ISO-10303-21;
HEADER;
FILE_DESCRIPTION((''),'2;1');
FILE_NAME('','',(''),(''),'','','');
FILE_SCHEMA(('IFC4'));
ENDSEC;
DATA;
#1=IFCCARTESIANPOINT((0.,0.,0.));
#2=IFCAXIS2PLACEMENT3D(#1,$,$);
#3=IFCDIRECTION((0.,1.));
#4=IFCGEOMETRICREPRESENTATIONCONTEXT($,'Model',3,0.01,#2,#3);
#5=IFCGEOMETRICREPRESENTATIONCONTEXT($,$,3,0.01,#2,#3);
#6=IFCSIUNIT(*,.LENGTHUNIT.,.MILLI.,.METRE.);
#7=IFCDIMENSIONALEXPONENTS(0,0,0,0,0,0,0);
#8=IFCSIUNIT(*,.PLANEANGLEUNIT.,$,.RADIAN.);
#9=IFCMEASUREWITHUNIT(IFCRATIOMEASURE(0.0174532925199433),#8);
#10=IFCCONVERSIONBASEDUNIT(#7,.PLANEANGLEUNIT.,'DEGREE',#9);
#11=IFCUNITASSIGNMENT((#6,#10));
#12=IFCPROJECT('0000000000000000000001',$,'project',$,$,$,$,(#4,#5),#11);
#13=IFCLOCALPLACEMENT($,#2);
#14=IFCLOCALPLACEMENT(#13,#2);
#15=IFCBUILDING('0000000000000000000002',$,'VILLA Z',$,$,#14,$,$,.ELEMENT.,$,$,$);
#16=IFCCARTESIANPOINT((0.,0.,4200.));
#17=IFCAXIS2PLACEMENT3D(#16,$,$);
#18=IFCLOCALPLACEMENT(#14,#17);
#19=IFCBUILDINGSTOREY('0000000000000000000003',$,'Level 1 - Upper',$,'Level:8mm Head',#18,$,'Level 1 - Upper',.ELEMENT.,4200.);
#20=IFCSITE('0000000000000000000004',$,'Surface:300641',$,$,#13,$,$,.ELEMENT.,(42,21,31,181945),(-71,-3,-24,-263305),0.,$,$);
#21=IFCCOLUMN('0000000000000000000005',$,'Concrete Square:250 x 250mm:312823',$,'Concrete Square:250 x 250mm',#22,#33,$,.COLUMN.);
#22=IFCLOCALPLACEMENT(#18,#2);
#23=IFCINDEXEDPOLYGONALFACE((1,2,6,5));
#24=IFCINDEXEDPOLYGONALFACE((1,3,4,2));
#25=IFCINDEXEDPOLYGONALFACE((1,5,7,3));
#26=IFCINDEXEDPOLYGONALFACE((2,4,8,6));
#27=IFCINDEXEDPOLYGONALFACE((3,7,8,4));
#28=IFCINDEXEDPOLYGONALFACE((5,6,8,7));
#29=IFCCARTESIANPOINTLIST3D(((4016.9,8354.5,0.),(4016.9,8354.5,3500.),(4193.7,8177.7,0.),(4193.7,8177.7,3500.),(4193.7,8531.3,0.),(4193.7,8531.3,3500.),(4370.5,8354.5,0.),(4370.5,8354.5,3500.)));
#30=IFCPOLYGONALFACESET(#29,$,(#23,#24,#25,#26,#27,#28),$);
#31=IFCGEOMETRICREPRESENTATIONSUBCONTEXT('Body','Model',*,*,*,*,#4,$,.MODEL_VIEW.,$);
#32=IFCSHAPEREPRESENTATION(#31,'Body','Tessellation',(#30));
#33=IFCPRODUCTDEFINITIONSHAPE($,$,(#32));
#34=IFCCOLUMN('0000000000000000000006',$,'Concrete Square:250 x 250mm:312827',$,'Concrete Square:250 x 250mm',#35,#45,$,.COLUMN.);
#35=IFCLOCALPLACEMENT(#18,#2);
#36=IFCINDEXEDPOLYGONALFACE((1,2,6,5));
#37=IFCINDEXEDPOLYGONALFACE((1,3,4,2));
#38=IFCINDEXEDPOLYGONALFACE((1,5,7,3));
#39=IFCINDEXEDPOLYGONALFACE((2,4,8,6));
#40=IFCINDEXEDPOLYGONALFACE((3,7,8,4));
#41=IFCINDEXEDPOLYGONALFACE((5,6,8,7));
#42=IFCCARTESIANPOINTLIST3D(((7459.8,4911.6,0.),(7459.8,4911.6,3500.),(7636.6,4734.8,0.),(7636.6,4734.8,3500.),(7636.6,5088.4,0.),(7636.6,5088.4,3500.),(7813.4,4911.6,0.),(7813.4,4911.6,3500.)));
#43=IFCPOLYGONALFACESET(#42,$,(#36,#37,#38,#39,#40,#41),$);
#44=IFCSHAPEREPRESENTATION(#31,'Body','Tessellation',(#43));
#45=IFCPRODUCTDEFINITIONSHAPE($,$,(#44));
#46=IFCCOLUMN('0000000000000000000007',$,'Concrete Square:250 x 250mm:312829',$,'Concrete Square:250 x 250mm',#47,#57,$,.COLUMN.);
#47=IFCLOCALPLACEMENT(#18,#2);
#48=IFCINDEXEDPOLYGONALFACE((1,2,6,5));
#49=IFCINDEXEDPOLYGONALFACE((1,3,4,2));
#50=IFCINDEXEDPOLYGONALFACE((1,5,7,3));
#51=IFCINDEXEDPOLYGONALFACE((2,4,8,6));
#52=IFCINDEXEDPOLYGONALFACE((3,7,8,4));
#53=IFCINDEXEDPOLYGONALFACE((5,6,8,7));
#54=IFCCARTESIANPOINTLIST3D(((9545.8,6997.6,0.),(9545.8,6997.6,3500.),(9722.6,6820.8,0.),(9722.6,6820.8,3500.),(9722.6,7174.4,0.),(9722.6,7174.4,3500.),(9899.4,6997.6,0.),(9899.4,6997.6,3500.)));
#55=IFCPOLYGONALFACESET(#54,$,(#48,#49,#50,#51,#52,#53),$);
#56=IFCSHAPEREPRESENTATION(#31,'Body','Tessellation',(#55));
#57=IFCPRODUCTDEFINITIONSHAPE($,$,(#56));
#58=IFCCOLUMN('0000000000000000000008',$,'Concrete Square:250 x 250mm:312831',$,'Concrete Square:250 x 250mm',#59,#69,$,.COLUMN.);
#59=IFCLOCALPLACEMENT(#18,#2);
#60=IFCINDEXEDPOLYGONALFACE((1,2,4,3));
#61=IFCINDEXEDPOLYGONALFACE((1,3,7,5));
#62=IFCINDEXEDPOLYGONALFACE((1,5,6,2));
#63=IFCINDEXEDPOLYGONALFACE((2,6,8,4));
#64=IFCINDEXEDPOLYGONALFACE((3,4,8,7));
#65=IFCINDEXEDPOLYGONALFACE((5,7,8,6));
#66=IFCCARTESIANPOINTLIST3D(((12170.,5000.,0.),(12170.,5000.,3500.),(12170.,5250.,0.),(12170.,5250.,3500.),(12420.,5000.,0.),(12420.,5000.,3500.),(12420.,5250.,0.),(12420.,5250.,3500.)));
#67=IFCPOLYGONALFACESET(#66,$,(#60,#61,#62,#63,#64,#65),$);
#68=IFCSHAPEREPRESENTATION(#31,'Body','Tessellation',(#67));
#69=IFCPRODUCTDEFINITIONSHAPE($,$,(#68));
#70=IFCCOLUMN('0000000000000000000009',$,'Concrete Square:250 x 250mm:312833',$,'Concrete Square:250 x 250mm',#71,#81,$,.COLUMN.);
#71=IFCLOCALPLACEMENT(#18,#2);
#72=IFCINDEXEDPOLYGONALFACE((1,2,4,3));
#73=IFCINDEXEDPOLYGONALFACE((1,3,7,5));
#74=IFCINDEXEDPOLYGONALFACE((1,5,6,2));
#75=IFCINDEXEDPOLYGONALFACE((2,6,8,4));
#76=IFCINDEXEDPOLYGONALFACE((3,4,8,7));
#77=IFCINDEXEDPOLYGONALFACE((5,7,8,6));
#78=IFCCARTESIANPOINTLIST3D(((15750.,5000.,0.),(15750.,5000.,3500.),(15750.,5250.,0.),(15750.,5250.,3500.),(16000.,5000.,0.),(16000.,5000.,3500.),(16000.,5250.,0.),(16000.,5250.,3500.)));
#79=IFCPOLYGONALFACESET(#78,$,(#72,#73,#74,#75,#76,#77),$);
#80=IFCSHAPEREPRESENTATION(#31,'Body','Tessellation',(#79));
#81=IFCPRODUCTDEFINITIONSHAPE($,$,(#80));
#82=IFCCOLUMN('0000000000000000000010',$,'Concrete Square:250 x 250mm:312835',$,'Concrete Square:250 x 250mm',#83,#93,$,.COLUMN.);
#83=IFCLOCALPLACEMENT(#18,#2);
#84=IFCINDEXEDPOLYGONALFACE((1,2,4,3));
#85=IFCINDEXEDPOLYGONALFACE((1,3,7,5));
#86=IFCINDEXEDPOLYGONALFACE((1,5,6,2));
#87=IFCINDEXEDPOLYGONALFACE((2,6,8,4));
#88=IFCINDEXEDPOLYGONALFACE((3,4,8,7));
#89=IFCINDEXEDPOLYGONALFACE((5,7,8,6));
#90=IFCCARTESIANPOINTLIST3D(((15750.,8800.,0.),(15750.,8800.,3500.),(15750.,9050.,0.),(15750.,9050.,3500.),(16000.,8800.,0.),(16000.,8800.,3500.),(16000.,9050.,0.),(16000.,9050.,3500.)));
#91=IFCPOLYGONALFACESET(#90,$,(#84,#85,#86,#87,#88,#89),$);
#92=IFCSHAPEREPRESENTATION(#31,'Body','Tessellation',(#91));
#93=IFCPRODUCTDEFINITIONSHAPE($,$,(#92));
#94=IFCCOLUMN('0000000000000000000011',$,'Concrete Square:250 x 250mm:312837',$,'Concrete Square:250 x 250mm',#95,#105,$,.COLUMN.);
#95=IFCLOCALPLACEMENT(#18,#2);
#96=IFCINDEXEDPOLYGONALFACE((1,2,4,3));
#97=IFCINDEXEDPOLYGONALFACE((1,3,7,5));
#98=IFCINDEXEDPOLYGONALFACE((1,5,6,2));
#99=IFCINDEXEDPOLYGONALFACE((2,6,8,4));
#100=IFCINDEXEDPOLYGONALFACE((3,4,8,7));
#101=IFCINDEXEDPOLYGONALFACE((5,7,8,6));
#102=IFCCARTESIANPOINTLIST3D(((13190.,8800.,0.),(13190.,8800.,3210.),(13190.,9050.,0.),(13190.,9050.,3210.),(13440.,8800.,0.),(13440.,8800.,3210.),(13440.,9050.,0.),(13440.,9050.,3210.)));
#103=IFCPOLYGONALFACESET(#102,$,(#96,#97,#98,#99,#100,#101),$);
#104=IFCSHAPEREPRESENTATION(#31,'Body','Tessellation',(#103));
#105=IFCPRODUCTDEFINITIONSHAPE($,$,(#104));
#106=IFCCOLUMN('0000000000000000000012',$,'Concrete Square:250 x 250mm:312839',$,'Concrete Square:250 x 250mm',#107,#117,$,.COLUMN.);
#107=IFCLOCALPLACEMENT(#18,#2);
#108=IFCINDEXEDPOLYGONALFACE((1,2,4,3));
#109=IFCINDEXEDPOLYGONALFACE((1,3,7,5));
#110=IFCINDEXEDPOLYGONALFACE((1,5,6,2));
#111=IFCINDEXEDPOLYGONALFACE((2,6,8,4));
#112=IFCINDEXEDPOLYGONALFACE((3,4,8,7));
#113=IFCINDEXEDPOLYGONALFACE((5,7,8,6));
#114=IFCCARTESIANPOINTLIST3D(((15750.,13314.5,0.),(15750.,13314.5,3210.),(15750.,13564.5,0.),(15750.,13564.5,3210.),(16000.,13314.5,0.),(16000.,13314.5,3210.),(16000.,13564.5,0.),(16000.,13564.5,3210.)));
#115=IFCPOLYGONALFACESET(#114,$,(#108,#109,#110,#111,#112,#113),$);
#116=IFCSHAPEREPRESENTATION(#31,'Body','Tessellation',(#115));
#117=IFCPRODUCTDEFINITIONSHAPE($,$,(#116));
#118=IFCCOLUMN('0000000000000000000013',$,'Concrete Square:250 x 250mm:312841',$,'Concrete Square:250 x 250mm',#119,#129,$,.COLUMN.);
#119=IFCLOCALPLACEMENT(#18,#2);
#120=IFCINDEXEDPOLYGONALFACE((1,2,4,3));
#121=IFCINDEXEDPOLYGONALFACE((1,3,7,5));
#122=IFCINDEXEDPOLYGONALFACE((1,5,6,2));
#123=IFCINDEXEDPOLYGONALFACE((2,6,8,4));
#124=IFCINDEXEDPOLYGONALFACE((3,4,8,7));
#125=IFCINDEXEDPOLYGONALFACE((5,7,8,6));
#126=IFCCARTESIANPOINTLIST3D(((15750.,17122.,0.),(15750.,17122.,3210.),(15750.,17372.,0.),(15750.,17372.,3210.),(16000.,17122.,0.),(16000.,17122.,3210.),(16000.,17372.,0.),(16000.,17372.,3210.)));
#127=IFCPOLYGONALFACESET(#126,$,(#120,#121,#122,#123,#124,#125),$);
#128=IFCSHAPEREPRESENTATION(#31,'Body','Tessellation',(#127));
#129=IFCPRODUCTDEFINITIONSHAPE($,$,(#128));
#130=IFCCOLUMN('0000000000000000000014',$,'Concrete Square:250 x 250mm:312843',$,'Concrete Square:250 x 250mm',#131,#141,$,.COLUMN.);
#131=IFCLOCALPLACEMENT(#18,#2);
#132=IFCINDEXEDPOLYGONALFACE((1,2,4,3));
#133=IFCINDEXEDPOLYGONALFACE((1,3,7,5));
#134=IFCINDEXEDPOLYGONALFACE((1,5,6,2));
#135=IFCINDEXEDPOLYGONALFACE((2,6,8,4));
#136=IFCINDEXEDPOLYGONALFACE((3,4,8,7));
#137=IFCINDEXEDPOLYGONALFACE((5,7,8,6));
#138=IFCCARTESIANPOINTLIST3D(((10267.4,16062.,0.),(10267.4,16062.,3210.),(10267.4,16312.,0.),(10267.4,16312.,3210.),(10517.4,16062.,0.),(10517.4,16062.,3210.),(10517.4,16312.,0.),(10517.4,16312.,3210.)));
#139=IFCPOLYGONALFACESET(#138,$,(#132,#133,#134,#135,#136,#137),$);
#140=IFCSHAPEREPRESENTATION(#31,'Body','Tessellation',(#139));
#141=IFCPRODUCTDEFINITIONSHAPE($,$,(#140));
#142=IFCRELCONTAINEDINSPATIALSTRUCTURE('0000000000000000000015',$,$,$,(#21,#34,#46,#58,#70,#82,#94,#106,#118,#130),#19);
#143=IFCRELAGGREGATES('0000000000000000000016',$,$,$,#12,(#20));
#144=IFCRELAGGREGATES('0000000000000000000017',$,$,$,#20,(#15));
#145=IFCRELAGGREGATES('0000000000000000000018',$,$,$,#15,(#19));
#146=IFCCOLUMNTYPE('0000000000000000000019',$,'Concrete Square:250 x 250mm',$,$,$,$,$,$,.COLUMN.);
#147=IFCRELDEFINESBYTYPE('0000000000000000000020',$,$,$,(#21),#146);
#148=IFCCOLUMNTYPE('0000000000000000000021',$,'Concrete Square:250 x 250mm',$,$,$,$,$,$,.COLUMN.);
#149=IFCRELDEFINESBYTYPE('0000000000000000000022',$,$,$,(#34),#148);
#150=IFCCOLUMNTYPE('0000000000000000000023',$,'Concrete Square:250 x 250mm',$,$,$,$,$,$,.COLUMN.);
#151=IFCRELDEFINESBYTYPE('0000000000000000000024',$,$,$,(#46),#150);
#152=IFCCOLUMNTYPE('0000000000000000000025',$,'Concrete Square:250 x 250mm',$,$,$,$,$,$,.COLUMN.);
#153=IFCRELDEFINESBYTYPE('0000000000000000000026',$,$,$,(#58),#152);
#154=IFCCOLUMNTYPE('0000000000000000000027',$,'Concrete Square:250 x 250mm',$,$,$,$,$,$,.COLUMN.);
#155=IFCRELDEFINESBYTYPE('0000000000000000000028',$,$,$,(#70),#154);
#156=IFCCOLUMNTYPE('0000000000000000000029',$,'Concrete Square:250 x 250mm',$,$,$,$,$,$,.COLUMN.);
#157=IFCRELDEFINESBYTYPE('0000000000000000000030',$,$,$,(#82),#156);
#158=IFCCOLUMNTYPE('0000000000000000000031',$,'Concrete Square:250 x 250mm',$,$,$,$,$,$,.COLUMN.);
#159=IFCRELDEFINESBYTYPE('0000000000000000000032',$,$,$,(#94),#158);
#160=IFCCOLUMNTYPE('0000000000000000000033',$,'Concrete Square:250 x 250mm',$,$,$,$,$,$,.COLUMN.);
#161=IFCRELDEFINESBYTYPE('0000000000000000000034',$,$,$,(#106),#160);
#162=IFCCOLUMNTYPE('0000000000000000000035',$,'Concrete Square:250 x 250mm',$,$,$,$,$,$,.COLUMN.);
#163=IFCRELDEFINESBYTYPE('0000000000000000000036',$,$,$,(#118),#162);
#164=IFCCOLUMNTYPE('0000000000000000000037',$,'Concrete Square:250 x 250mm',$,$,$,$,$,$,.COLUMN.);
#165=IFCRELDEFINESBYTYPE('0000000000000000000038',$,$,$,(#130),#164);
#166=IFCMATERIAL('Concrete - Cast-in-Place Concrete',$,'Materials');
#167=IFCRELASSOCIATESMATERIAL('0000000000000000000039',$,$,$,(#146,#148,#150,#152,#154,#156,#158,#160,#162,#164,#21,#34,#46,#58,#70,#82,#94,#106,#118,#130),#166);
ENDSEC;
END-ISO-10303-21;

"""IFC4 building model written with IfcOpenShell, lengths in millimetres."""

from ifc_helpers import new_model, entity, si_unit, converted_unit, direction, frame, frame_2d, origin, origin_2d_with_axis, place, context, subcontext, project, spatial, rectangle, extrude, source, transform, mapped, material, material_profile, profile_set, profile_usage, type_object, type_shapes, element, save


model = new_model("IFC4")

# Units and contexts
model_context = context("Model", 3, precision=0.01, world=origin(), true_north=direction((0.0, 1.0)))
context_of_model = context(None, 3, precision=0.01, world=origin(), true_north=direction((0.0, 1.0)))
body_context = subcontext(model_context, "Body", "Model", "MODEL_VIEW")
ifc_project = project(units=[si_unit("LENGTHUNIT", "METRE", prefix="MILLI"), converted_unit("PLANEANGLEUNIT", "DEGREE", entity("IfcRatioMeasure", 0.0174532925199433), si_unit("PLANEANGLEUNIT", "RADIAN"), dimensions=[0, 0, 0, 0, 0, 0, 0])], contexts=[model_context, context_of_model])

# Site, building, storey
site_placement = place(None, origin())
site = spatial("IfcSite", under=ifc_project, at=site_placement, Name="Surface:300641", CompositionType="ELEMENT", RefLatitude=(42, 21, 31, 181945), RefLongitude=(-71, -3, -24, -263305), RefElevation=0.0)
building_placement = place(site_placement, origin())
building = spatial("IfcBuilding", under=site, at=building_placement, Name="VILLA Z", CompositionType="ELEMENT")
storey_placement = place(building_placement, frame((0.0, 0.0, 4200.0)))
storey = spatial("IfcBuildingStorey", under=building, at=storey_placement, Name="Level 1 - Upper", ObjectType="Level:8mm Head", LongName="Level 1 - Upper", CompositionType="ELEMENT", Elevation=4200.0)

# Columns
ifc_material = material(Name="Concrete - Cast-in-Place Concrete", Category="Materials")
ifc_material_profile_1 = material_profile(ifc_material, rectangle(XDim=250.0, YDim=250.0, at=frame_2d((0.0, 0.0), x_axis=(1.0, 0.0))), Name="250 x 250mm")
ifc_profile_set_1 = profile_set([ifc_material_profile_1], Name="250 x 250mm")
ifc_profile_usage_1 = profile_usage(ifc_profile_set_1)
column_type_1 = type_object("IfcColumnType", Name="Concrete Square:250 x 250mm", PredefinedType="COLUMN", material=ifc_profile_set_1)
shared_shape_1 = source(origin(), body_context, "Body", "SweptSolid", [
    extrude(rectangle(XDim=250.0, YDim=250.0, at=frame_2d((0.0, 0.0), x_axis=(1.0, 0.0))), frame((4193.7, 8354.5, 4200.0), z_axis=(0.0, 0.0, 1.0), x_axis=(-0.707107, 0.707107, 0.0)), (0.0, 0.0, 1.0), 3500.0),
])
type_shapes(column_type_1, [shared_shape_1])
column_1_placement = place(storey_placement, frame((0.0, 0.0, -4200.0)))
element("IfcColumn", 1, at=column_1_placement, inside=storey, type_object=column_type_1, material=ifc_profile_usage_1, Name="Concrete Square:250 x 250mm:312823", ObjectType="Concrete Square:250 x 250mm", PredefinedType="COLUMN", context=body_context, shape_type="MappedRepresentation", body=[
    mapped(shared_shape_1, transform((0.0, 0.0, 0.0), scale=1.0)),
])
ifc_profile_usage_2 = profile_usage(ifc_profile_set_1)
column_type_2 = type_object("IfcColumnType", Name="Concrete Square:250 x 250mm", PredefinedType="COLUMN", material=ifc_profile_set_1)
shared_shape_2 = source(origin(), body_context, "Body", "SweptSolid", [
    extrude(rectangle(XDim=250.0, YDim=250.0, at=frame_2d((0.0, 0.0), x_axis=(1.0, 0.0))), frame((7636.6, 4911.6, 4200.0), z_axis=(0.0, 0.0, 1.0), x_axis=(-0.707107, 0.707107, 0.0)), (0.0, 0.0, 1.0), 3500.0),
])
type_shapes(column_type_2, [shared_shape_2])
column_2_placement = place(storey_placement, frame((0.0, 0.0, -4200.0)))
element("IfcColumn", 2, at=column_2_placement, inside=storey, type_object=column_type_2, material=ifc_profile_usage_2, Name="Concrete Square:250 x 250mm:312827", ObjectType="Concrete Square:250 x 250mm", PredefinedType="COLUMN", context=body_context, shape_type="MappedRepresentation", body=[
    mapped(shared_shape_2, transform((0.0, 0.0, 0.0), scale=1.0)),
])
ifc_profile_usage_3 = profile_usage(ifc_profile_set_1)
column_type_3 = type_object("IfcColumnType", Name="Concrete Square:250 x 250mm", PredefinedType="COLUMN", material=ifc_profile_set_1)
shared_shape_3 = source(origin(), body_context, "Body", "SweptSolid", [
    extrude(rectangle(XDim=250.0, YDim=250.0, at=frame_2d((0.0, 0.0), x_axis=(1.0, 0.0))), frame((9722.6, 6997.6, 4200.0), z_axis=(0.0, 0.0, 1.0), x_axis=(-0.707107, 0.707107, 0.0)), (0.0, 0.0, 1.0), 3500.0),
])
type_shapes(column_type_3, [shared_shape_3])
column_3_placement = place(storey_placement, frame((0.0, 0.0, -4200.0)))
element("IfcColumn", 3, at=column_3_placement, inside=storey, type_object=column_type_3, material=ifc_profile_usage_3, Name="Concrete Square:250 x 250mm:312829", ObjectType="Concrete Square:250 x 250mm", PredefinedType="COLUMN", context=body_context, shape_type="MappedRepresentation", body=[
    mapped(shared_shape_3, transform((0.0, 0.0, 0.0), scale=1.0)),
])
ifc_profile_usage_4 = profile_usage(ifc_profile_set_1)
column_type_4 = type_object("IfcColumnType", Name="Concrete Square:250 x 250mm", PredefinedType="COLUMN", material=ifc_profile_set_1)
shared_shape_4 = source(origin(), body_context, "Body", "SweptSolid", [
    extrude(rectangle(XDim=250.0, YDim=250.0, at=origin_2d_with_axis()), frame((12295.0, 5125.0, 4200.0), z_axis=(0.0, 0.0, 1.0), x_axis=(0.0, -1.0, 0.0)), (0.0, 0.0, 1.0), 3500.0),
])
type_shapes(column_type_4, [shared_shape_4])
column_4_placement = place(storey_placement, frame((0.0, 0.0, -4200.0)))
element("IfcColumn", 4, at=column_4_placement, inside=storey, type_object=column_type_4, material=ifc_profile_usage_4, Name="Concrete Square:250 x 250mm:312831", ObjectType="Concrete Square:250 x 250mm", PredefinedType="COLUMN", context=body_context, shape_type="MappedRepresentation", body=[
    mapped(shared_shape_4, transform((0.0, 0.0, 0.0), scale=1.0)),
])
ifc_profile_usage_5 = profile_usage(ifc_profile_set_1)
column_type_5 = type_object("IfcColumnType", Name="Concrete Square:250 x 250mm", PredefinedType="COLUMN", material=ifc_profile_set_1)
shared_shape_5 = source(origin(), body_context, "Body", "SweptSolid", [
    extrude(rectangle(XDim=250.0, YDim=250.0, at=origin_2d_with_axis()), frame((15875.0, 5125.0, 4200.0), z_axis=(0.0, 0.0, 1.0), x_axis=(0.0, -1.0, 0.0)), (0.0, 0.0, 1.0), 3500.0),
])
type_shapes(column_type_5, [shared_shape_5])
column_5_placement = place(storey_placement, frame((0.0, 0.0, -4200.0)))
element("IfcColumn", 5, at=column_5_placement, inside=storey, type_object=column_type_5, material=ifc_profile_usage_5, Name="Concrete Square:250 x 250mm:312833", ObjectType="Concrete Square:250 x 250mm", PredefinedType="COLUMN", context=body_context, shape_type="MappedRepresentation", body=[
    mapped(shared_shape_5, transform((0.0, 0.0, 0.0), scale=1.0)),
])
ifc_profile_usage_6 = profile_usage(ifc_profile_set_1)
column_type_6 = type_object("IfcColumnType", Name="Concrete Square:250 x 250mm", PredefinedType="COLUMN", material=ifc_profile_set_1)
shared_shape_6 = source(origin(), body_context, "Body", "SweptSolid", [
    extrude(rectangle(XDim=250.0, YDim=250.0, at=origin_2d_with_axis()), frame((15875.0, 8925.0, 4200.0)), (0.0, 0.0, 1.0), 3500.0),
])
type_shapes(column_type_6, [shared_shape_6])
column_6_placement = place(storey_placement, frame((0.0, 0.0, -4200.0)))
element("IfcColumn", 6, at=column_6_placement, inside=storey, type_object=column_type_6, material=ifc_profile_usage_6, Name="Concrete Square:250 x 250mm:312835", ObjectType="Concrete Square:250 x 250mm", PredefinedType="COLUMN", context=body_context, shape_type="MappedRepresentation", body=[
    mapped(shared_shape_6, transform((0.0, 0.0, 0.0), scale=1.0)),
])
ifc_profile_usage_7 = profile_usage(ifc_profile_set_1)
column_type_7 = type_object("IfcColumnType", Name="Concrete Square:250 x 250mm", PredefinedType="COLUMN", material=ifc_profile_set_1)
shared_shape_7 = source(origin(), body_context, "Body", "SweptSolid", [
    extrude(rectangle(XDim=250.0, YDim=250.0, at=frame_2d((0.0, 0.0), x_axis=(1.0, 0.0))), frame((13315.0, 8925.0, 4200.0), z_axis=(0.0, 0.0, 1.0), x_axis=(0.0, -1.0, 0.0)), (0.0, 0.0, 1.0), 3210.0),
])
type_shapes(column_type_7, [shared_shape_7])
column_7_placement = place(storey_placement, frame((0.0, 0.0, -4200.0)))
element("IfcColumn", 7, at=column_7_placement, inside=storey, type_object=column_type_7, material=ifc_profile_usage_7, Name="Concrete Square:250 x 250mm:312837", ObjectType="Concrete Square:250 x 250mm", PredefinedType="COLUMN", context=body_context, shape_type="MappedRepresentation", body=[
    mapped(shared_shape_7, transform((0.0, 0.0, 0.0), scale=1.0)),
])
ifc_profile_usage_8 = profile_usage(ifc_profile_set_1)
column_type_8 = type_object("IfcColumnType", Name="Concrete Square:250 x 250mm", PredefinedType="COLUMN", material=ifc_profile_set_1)
shared_shape_8 = source(origin(), body_context, "Body", "SweptSolid", [
    extrude(rectangle(XDim=250.0, YDim=250.0, at=frame_2d((0.0, 0.0), x_axis=(1.0, 0.0))), frame((15875.0, 13439.5, 4200.0), z_axis=(0.0, 0.0, 1.0), x_axis=(0.0, -1.0, 0.0)), (0.0, 0.0, 1.0), 3210.0),
])
type_shapes(column_type_8, [shared_shape_8])
column_8_placement = place(storey_placement, frame((0.0, 0.0, -4200.0)))
element("IfcColumn", 8, at=column_8_placement, inside=storey, type_object=column_type_8, material=ifc_profile_usage_8, Name="Concrete Square:250 x 250mm:312839", ObjectType="Concrete Square:250 x 250mm", PredefinedType="COLUMN", context=body_context, shape_type="MappedRepresentation", body=[
    mapped(shared_shape_8, transform((0.0, 0.0, 0.0), scale=1.0)),
])
ifc_profile_usage_9 = profile_usage(ifc_profile_set_1)
column_type_9 = type_object("IfcColumnType", Name="Concrete Square:250 x 250mm", PredefinedType="COLUMN", material=ifc_profile_set_1)
shared_shape_9 = source(origin(), body_context, "Body", "SweptSolid", [
    extrude(rectangle(XDim=250.0, YDim=250.0, at=origin_2d_with_axis()), frame((15875.0, 17247.0, 4200.0), z_axis=(0.0, 0.0, 1.0), x_axis=(0.0, -1.0, 0.0)), (0.0, 0.0, 1.0), 3210.0),
])
type_shapes(column_type_9, [shared_shape_9])
column_9_placement = place(storey_placement, frame((0.0, 0.0, -4200.0)))
element("IfcColumn", 9, at=column_9_placement, inside=storey, type_object=column_type_9, material=ifc_profile_usage_9, Name="Concrete Square:250 x 250mm:312841", ObjectType="Concrete Square:250 x 250mm", PredefinedType="COLUMN", context=body_context, shape_type="MappedRepresentation", body=[
    mapped(shared_shape_9, transform((0.0, 0.0, 0.0), scale=1.0)),
])
ifc_profile_usage_10 = profile_usage(ifc_profile_set_1)
column_type_10 = type_object("IfcColumnType", Name="Concrete Square:250 x 250mm", PredefinedType="COLUMN", material=ifc_profile_set_1)
shared_shape_10 = source(origin(), body_context, "Body", "SweptSolid", [
    extrude(rectangle(XDim=250.0, YDim=250.0, at=frame_2d((0.0, 0.0), x_axis=(1.0, 0.0))), frame((10392.4, 16187.0, 4200.0), z_axis=(0.0, 0.0, 1.0), x_axis=(0.0, -1.0, 0.0)), (0.0, 0.0, 1.0), 3210.0),
])
type_shapes(column_type_10, [shared_shape_10])
column_10_placement = place(storey_placement, frame((0.0, 0.0, -4200.0)))
element("IfcColumn", 10, at=column_10_placement, inside=storey, type_object=column_type_10, material=ifc_profile_usage_10, Name="Concrete Square:250 x 250mm:312843", ObjectType="Concrete Square:250 x 250mm", PredefinedType="COLUMN", context=body_context, shape_type="MappedRepresentation", body=[
    mapped(shared_shape_10, transform((0.0, 0.0, 0.0), scale=1.0)),
])

save(model, "model.ifc")
